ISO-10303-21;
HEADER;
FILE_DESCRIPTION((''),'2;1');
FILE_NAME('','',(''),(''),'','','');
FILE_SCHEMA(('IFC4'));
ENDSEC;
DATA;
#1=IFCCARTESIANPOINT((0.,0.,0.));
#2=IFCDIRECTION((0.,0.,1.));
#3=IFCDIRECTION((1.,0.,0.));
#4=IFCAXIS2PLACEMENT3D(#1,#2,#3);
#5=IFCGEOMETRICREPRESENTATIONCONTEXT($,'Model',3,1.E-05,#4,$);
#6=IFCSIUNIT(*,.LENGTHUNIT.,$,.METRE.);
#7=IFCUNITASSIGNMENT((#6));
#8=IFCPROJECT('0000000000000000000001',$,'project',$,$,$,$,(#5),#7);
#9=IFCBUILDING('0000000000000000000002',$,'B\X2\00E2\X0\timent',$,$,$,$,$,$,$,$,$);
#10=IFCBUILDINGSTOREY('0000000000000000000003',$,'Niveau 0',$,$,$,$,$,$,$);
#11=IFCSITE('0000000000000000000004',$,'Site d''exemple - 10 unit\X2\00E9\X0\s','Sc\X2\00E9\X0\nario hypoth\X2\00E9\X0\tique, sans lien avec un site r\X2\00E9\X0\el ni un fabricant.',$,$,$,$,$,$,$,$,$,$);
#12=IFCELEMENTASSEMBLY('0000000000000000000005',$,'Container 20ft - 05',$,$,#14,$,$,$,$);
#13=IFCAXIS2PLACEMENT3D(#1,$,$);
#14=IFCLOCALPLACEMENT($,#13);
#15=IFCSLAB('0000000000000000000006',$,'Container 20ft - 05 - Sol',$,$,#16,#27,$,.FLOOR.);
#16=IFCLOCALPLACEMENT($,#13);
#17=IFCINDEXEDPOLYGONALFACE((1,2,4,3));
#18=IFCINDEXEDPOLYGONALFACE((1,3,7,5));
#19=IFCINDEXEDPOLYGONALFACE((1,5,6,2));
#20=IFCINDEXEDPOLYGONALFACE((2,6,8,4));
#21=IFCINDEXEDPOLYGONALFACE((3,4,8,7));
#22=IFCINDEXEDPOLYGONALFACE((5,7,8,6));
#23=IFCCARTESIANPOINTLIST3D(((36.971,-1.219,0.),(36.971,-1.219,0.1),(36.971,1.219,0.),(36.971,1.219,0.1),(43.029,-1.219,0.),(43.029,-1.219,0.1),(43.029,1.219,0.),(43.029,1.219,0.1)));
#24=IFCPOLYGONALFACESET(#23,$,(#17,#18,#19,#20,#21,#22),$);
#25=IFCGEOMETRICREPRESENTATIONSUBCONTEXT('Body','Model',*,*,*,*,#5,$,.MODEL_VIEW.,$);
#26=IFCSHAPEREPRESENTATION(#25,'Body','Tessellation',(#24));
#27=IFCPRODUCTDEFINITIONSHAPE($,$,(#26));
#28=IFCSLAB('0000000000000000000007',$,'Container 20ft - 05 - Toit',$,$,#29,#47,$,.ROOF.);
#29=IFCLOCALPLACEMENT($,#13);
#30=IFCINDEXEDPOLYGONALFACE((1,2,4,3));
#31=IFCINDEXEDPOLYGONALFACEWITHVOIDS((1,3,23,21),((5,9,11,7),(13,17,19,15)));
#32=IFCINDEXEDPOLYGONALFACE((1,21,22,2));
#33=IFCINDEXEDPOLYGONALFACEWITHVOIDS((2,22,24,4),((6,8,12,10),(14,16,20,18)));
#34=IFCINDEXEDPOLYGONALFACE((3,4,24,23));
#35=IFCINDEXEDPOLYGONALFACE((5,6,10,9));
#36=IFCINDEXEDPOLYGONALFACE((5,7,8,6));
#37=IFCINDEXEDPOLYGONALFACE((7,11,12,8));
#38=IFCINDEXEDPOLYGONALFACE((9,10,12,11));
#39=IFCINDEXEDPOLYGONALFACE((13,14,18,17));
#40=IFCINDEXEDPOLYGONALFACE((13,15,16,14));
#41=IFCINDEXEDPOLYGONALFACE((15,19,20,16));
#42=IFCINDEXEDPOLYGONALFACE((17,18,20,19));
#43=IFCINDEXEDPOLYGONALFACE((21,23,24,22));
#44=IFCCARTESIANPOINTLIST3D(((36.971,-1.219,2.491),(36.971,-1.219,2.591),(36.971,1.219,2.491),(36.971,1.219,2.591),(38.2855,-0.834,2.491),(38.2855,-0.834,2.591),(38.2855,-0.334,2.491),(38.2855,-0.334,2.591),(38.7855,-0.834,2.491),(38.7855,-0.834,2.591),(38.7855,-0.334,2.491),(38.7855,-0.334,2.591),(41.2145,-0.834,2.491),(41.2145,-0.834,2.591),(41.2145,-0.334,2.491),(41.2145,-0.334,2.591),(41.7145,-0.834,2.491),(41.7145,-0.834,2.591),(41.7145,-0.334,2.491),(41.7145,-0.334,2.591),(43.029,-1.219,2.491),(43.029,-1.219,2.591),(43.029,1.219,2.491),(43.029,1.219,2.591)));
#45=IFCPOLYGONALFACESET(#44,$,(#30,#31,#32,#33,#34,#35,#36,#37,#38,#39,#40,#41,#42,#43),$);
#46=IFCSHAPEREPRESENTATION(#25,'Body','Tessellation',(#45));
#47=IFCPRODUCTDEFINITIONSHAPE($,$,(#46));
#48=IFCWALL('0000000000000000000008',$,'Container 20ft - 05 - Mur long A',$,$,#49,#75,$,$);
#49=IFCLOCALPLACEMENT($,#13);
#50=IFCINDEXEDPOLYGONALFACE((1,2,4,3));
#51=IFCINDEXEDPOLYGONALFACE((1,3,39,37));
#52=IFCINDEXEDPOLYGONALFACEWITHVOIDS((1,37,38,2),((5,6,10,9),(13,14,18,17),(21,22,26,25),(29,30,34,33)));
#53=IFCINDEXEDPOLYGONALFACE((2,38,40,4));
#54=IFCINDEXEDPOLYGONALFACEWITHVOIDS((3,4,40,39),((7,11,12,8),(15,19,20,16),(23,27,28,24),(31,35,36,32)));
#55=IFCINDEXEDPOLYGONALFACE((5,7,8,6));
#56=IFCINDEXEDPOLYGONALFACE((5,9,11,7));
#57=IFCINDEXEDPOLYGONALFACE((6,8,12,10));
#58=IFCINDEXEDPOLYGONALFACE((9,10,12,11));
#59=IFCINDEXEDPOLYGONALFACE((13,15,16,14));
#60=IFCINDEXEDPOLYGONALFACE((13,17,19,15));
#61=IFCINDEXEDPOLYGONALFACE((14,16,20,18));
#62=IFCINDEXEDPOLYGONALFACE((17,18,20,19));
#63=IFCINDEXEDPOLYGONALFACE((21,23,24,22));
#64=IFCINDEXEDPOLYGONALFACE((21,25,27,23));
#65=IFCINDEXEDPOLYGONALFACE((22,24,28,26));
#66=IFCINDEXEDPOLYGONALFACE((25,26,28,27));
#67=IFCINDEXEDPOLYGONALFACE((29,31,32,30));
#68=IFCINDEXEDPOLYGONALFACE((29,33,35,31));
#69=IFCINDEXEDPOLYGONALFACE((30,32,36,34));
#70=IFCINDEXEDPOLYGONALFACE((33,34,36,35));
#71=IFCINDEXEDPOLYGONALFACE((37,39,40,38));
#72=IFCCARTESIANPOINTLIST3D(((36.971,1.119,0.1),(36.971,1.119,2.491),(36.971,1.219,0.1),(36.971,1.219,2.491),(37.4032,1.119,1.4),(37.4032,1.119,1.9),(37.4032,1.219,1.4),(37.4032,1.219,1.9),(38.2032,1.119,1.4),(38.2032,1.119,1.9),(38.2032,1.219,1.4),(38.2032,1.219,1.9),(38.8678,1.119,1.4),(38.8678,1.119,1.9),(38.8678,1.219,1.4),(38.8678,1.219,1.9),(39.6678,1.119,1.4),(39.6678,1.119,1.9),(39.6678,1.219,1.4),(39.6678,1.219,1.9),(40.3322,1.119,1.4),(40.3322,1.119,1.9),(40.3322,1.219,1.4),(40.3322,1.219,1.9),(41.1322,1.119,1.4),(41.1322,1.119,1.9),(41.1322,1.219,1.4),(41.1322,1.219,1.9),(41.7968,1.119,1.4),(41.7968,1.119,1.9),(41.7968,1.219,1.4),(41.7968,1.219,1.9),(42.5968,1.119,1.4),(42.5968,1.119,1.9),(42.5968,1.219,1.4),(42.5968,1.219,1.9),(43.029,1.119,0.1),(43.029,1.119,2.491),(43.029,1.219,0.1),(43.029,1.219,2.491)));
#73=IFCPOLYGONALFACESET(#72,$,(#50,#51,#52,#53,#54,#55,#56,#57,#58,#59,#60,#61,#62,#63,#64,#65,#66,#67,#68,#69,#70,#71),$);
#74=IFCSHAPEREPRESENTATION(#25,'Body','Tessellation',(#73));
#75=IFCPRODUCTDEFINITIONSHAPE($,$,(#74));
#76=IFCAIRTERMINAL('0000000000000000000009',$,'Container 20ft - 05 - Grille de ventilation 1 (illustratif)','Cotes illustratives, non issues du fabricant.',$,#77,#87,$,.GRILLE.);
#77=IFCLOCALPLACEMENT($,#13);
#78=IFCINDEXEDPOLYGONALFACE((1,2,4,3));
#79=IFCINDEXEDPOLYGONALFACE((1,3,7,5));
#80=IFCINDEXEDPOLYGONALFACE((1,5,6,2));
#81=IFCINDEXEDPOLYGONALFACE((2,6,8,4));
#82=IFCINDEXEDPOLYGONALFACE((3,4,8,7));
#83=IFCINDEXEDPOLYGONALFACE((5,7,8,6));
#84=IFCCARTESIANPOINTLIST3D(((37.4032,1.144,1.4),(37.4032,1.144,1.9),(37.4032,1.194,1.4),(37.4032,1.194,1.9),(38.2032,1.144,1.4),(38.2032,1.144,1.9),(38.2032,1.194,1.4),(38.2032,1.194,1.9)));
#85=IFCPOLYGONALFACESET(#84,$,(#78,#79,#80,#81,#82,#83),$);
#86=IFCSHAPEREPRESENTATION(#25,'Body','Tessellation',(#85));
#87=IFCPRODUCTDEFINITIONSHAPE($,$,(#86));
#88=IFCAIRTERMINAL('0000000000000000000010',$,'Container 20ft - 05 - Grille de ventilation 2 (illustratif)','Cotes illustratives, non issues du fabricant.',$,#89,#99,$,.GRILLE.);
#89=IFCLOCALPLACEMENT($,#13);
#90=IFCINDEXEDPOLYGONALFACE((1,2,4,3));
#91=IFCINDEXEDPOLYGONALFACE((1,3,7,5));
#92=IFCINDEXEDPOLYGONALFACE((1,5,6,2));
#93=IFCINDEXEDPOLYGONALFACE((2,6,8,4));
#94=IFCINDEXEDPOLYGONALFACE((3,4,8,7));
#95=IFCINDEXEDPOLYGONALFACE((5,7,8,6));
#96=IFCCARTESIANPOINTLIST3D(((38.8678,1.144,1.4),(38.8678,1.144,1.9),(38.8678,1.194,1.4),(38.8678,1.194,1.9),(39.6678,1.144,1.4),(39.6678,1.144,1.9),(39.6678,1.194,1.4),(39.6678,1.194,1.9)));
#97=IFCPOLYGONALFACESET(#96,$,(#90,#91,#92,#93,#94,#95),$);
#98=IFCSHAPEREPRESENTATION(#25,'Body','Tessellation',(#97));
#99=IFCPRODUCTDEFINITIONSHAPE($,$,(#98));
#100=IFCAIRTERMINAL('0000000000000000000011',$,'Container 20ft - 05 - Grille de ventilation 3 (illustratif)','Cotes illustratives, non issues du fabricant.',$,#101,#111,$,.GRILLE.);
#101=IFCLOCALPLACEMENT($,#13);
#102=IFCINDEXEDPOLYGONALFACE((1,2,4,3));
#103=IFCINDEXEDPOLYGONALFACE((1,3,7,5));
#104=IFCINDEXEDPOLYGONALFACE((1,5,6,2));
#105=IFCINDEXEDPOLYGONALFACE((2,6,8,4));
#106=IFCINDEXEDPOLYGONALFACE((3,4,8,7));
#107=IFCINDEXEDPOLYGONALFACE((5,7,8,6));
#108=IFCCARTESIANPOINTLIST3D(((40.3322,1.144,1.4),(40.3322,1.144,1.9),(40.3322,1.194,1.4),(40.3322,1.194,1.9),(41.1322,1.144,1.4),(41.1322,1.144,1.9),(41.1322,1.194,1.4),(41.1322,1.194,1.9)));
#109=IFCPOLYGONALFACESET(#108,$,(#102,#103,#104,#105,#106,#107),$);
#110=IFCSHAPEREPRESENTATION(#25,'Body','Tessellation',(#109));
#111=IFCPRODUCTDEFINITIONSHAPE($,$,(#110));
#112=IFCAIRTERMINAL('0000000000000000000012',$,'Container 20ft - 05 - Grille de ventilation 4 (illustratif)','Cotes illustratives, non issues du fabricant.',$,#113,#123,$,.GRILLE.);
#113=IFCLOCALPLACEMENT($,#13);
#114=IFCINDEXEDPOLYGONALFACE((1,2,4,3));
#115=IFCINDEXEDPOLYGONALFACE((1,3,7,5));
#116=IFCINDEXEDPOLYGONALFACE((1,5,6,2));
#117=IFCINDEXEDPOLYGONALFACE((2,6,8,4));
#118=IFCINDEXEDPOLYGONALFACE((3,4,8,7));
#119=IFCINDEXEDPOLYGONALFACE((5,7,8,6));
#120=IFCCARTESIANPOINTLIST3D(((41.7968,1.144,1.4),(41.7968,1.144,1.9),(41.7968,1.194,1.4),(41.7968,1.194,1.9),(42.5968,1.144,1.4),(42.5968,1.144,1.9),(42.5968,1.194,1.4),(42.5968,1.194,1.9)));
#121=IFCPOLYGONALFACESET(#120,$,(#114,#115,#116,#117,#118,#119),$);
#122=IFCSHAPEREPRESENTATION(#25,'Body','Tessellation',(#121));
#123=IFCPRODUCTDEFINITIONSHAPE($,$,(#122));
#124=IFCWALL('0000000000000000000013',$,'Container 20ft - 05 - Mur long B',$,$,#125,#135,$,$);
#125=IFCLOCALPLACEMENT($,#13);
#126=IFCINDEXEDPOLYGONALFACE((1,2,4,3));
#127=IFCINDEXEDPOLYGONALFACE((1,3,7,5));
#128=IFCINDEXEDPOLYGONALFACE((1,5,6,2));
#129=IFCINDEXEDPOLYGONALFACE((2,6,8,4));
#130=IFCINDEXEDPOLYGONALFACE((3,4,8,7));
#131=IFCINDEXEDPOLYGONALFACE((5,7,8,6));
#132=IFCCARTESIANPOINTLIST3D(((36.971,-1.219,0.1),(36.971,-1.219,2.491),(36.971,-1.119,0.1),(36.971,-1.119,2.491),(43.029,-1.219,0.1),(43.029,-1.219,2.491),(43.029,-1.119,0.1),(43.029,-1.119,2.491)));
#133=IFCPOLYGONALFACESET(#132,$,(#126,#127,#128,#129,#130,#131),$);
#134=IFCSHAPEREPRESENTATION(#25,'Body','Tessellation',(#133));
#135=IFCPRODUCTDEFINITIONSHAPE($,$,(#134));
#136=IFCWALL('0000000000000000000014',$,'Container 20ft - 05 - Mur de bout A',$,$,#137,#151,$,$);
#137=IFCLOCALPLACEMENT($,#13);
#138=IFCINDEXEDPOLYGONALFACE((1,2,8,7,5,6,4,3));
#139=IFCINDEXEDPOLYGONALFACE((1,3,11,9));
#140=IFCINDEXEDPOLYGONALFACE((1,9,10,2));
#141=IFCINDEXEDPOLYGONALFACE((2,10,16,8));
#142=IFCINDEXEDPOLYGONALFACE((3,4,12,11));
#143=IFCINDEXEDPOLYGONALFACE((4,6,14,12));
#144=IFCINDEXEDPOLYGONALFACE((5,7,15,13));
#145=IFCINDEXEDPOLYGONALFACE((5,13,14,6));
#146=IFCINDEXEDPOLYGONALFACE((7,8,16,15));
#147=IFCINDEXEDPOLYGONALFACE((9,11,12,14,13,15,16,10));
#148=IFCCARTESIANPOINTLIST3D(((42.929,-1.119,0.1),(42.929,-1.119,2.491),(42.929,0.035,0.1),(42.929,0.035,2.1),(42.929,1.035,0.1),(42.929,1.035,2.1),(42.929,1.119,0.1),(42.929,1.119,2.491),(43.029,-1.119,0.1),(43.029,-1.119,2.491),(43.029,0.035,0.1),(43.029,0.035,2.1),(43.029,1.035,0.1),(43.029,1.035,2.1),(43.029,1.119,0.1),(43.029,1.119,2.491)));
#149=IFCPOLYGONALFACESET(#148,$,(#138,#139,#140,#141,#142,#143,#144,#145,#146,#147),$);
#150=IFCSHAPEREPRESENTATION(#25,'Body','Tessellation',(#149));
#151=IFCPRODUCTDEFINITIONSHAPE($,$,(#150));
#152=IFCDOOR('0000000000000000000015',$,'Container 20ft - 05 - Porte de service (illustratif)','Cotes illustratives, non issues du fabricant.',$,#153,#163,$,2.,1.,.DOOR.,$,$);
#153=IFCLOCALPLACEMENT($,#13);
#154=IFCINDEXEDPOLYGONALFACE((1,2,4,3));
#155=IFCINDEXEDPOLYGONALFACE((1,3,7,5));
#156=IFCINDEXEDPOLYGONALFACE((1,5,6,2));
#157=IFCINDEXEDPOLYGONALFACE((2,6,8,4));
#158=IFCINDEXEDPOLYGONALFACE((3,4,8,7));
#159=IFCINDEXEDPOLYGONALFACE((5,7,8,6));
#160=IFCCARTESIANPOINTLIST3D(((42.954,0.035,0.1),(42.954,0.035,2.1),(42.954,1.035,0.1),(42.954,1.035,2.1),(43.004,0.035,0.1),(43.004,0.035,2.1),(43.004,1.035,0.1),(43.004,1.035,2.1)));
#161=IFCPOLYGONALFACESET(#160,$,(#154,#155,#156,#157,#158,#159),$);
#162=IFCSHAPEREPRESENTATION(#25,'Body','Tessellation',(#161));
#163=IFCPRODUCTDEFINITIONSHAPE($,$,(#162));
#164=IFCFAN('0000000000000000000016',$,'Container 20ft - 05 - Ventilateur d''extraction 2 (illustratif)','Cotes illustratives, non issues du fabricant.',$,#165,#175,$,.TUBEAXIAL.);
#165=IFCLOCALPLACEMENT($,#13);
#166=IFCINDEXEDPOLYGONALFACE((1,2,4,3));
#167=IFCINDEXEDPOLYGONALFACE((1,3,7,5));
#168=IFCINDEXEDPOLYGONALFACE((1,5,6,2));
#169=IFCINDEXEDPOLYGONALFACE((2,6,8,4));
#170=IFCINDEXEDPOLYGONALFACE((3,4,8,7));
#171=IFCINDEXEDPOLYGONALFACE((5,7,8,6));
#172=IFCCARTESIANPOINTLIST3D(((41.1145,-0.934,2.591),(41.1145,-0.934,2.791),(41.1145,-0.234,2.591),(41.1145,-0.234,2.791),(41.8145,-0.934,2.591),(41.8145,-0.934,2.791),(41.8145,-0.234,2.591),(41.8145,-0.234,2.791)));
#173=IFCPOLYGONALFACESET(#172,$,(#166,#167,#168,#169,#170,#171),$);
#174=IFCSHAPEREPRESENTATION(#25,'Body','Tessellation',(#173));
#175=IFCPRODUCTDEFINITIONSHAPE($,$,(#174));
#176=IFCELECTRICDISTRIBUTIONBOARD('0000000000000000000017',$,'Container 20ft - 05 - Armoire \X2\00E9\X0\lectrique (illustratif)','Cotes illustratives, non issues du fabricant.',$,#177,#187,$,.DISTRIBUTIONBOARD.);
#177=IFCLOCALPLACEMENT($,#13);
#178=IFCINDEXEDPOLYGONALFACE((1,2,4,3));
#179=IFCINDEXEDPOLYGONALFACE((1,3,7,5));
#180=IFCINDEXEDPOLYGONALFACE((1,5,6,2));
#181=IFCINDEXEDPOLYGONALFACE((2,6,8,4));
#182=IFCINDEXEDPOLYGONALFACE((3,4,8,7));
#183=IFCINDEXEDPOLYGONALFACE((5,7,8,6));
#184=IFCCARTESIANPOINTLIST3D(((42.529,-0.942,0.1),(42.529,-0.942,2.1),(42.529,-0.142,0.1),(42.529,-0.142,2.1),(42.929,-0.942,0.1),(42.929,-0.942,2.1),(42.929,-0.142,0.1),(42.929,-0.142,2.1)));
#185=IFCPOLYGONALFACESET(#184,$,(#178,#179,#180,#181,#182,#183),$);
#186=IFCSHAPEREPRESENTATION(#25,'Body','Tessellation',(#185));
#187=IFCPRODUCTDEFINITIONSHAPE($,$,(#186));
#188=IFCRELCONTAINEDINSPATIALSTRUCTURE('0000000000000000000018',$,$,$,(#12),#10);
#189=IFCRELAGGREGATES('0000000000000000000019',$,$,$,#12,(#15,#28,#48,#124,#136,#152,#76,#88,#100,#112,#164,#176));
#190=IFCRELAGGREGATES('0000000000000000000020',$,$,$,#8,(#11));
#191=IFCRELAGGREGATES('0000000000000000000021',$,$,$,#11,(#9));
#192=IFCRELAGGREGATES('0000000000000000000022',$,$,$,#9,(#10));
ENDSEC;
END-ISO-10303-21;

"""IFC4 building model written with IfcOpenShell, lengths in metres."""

from ifc_helpers import new_model, si_unit, frame, origin_with_axes, place, context, subcontext, project, spatial, rectangle, extrude, element, fill, aggregate, save


model = new_model("IFC4")

# Units and contexts
model_context = context("Model", 3, precision=1e-05, world=origin_with_axes())
body_context = subcontext(model_context, "Body", "Model", "MODEL_VIEW")
ifc_project = project(units=[si_unit("LENGTHUNIT", "METRE")], contexts=[model_context])

# Site, building, storey
site = spatial("IfcSite", under=ifc_project, Name="Site d'exemple - 10 unités", Description="Scénario hypothétique, sans lien avec un site réel ni un fabricant.")
building = spatial("IfcBuilding", under=site, Name="Bâtiment")
storey = spatial("IfcBuildingStorey", under=building, Name="Niveau 0")

# Element assembly, slabs, openings, walls, air terminals, door, fan, electric distribution board
assembly = element("IfcElementAssembly", 1, inside=storey, Name="Container 20ft - 05")
slab_1_placement = place(None, frame((40.0, 0.0, 0.0), z_axis=(0.0, 0.0, 1.0), x_axis=(1.0, 0.0, 0.0)))
slab_1 = element("IfcSlab", 2, at=slab_1_placement, Name="Container 20ft - 05 - Sol", PredefinedType="FLOOR", context=body_context, shape_type="SweptSolid", body=[
    extrude(rectangle(XDim=6.058, YDim=2.438), origin_with_axes(), (0.0, 0.0, 1.0), 0.1),
])
slab_2_placement = place(None, frame((40.0, 0.0, 2.491), z_axis=(0.0, 0.0, 1.0), x_axis=(1.0, 0.0, 0.0)))
slab_2 = element("IfcSlab", 3, at=slab_2_placement, Name="Container 20ft - 05 - Toit", PredefinedType="ROOF", context=body_context, shape_type="SweptSolid", body=[
    extrude(rectangle(XDim=6.058, YDim=2.438), origin_with_axes(), (0.0, 0.0, 1.0), 0.1),
])
opening_1_placement = place(None, frame((38.5355, -0.584, 2.441), z_axis=(0.0, 0.0, 1.0), x_axis=(1.0, 0.0, 0.0)))
element("IfcOpeningElement", 4, at=opening_1_placement, cuts=slab_2, PredefinedType="OPENING", context=body_context, shape_type="SweptSolid", body=[
    extrude(rectangle(XDim=0.5, YDim=0.5), origin_with_axes(), (0.0, 0.0, 1.0), 0.2),
])
opening_2_placement = place(None, frame((41.4645, -0.584, 2.441), z_axis=(0.0, 0.0, 1.0), x_axis=(1.0, 0.0, 0.0)))
element("IfcOpeningElement", 5, at=opening_2_placement, cuts=slab_2, PredefinedType="OPENING", context=body_context, shape_type="SweptSolid", body=[
    extrude(rectangle(XDim=0.5, YDim=0.5), origin_with_axes(), (0.0, 0.0, 1.0), 0.2),
])
wall_1_placement = place(None, frame((40.0, 1.169, 0.1), z_axis=(0.0, 0.0, 1.0), x_axis=(1.0, 0.0, 0.0)))
wall_1 = element("IfcWall", 6, at=wall_1_placement, Name="Container 20ft - 05 - Mur long A", context=body_context, shape_type="SweptSolid", body=[
    extrude(rectangle(XDim=6.058, YDim=0.1), origin_with_axes(), (0.0, 0.0, 1.0), 2.391),
])
opening_3_placement = place(None, frame((37.8032, 1.169, 1.4), z_axis=(0.0, 0.0, 1.0), x_axis=(1.0, 0.0, 0.0)))
opening_3 = element("IfcOpeningElement", 7, at=opening_3_placement, cuts=wall_1, PredefinedType="OPENING", context=body_context, shape_type="SweptSolid", body=[
    extrude(rectangle(XDim=0.8, YDim=0.2), origin_with_axes(), (0.0, 0.0, 1.0), 0.5),
])
opening_4_placement = place(None, frame((39.2677, 1.169, 1.4), z_axis=(0.0, 0.0, 1.0), x_axis=(1.0, 0.0, 0.0)))
opening_4 = element("IfcOpeningElement", 8, at=opening_4_placement, cuts=wall_1, PredefinedType="OPENING", context=body_context, shape_type="SweptSolid", body=[
    extrude(rectangle(XDim=0.8, YDim=0.2), origin_with_axes(), (0.0, 0.0, 1.0), 0.5),
])
opening_5_placement = place(None, frame((40.7323, 1.169, 1.4), z_axis=(0.0, 0.0, 1.0), x_axis=(1.0, 0.0, 0.0)))
opening_5 = element("IfcOpeningElement", 9, at=opening_5_placement, cuts=wall_1, PredefinedType="OPENING", context=body_context, shape_type="SweptSolid", body=[
    extrude(rectangle(XDim=0.8, YDim=0.2), origin_with_axes(), (0.0, 0.0, 1.0), 0.5),
])
opening_6_placement = place(None, frame((42.1968, 1.169, 1.4), z_axis=(0.0, 0.0, 1.0), x_axis=(1.0, 0.0, 0.0)))
opening_6 = element("IfcOpeningElement", 10, at=opening_6_placement, cuts=wall_1, PredefinedType="OPENING", context=body_context, shape_type="SweptSolid", body=[
    extrude(rectangle(XDim=0.8, YDim=0.2), origin_with_axes(), (0.0, 0.0, 1.0), 0.5),
])
air_terminal_1_placement = place(None, frame((37.8032, 1.169, 1.4), z_axis=(0.0, 0.0, 1.0), x_axis=(1.0, 0.0, 0.0)))
air_terminal_1 = element("IfcAirTerminal", 11, at=air_terminal_1_placement, Name="Container 20ft - 05 - Grille de ventilation 1 (illustratif)", Description="Cotes illustratives, non issues du fabricant.", PredefinedType="GRILLE", context=body_context, shape_type="SweptSolid", body=[
    extrude(rectangle(XDim=0.8, YDim=0.05), origin_with_axes(), (0.0, 0.0, 1.0), 0.5),
])
fill(opening_3, air_terminal_1)
air_terminal_2_placement = place(None, frame((39.2677, 1.169, 1.4), z_axis=(0.0, 0.0, 1.0), x_axis=(1.0, 0.0, 0.0)))
air_terminal_2 = element("IfcAirTerminal", 12, at=air_terminal_2_placement, Name="Container 20ft - 05 - Grille de ventilation 2 (illustratif)", Description="Cotes illustratives, non issues du fabricant.", PredefinedType="GRILLE", context=body_context, shape_type="SweptSolid", body=[
    extrude(rectangle(XDim=0.8, YDim=0.05), origin_with_axes(), (0.0, 0.0, 1.0), 0.5),
])
fill(opening_4, air_terminal_2)
air_terminal_3_placement = place(None, frame((40.7323, 1.169, 1.4), z_axis=(0.0, 0.0, 1.0), x_axis=(1.0, 0.0, 0.0)))
air_terminal_3 = element("IfcAirTerminal", 13, at=air_terminal_3_placement, Name="Container 20ft - 05 - Grille de ventilation 3 (illustratif)", Description="Cotes illustratives, non issues du fabricant.", PredefinedType="GRILLE", context=body_context, shape_type="SweptSolid", body=[
    extrude(rectangle(XDim=0.8, YDim=0.05), origin_with_axes(), (0.0, 0.0, 1.0), 0.5),
])
fill(opening_5, air_terminal_3)
air_terminal_4_placement = place(None, frame((42.1968, 1.169, 1.4), z_axis=(0.0, 0.0, 1.0), x_axis=(1.0, 0.0, 0.0)))
air_terminal_4 = element("IfcAirTerminal", 14, at=air_terminal_4_placement, Name="Container 20ft - 05 - Grille de ventilation 4 (illustratif)", Description="Cotes illustratives, non issues du fabricant.", PredefinedType="GRILLE", context=body_context, shape_type="SweptSolid", body=[
    extrude(rectangle(XDim=0.8, YDim=0.05), origin_with_axes(), (0.0, 0.0, 1.0), 0.5),
])
fill(opening_6, air_terminal_4)
wall_2_placement = place(None, frame((40.0, -1.169, 0.1), z_axis=(0.0, 0.0, 1.0), x_axis=(1.0, 0.0, 0.0)))
wall_2 = element("IfcWall", 15, at=wall_2_placement, Name="Container 20ft - 05 - Mur long B", context=body_context, shape_type="SweptSolid", body=[
    extrude(rectangle(XDim=6.058, YDim=0.1), origin_with_axes(), (0.0, 0.0, 1.0), 2.391),
])
wall_3_placement = place(None, frame((42.979, 0.0, 0.1), z_axis=(0.0, 0.0, 1.0), x_axis=(1.0, 0.0, 0.0)))
wall_3 = element("IfcWall", 16, at=wall_3_placement, Name="Container 20ft - 05 - Mur de bout A", context=body_context, shape_type="SweptSolid", body=[
    extrude(rectangle(XDim=0.1, YDim=2.238), origin_with_axes(), (0.0, 0.0, 1.0), 2.391),
])
opening_7_placement = place(None, frame((42.979, 0.535, 0.1), z_axis=(0.0, 0.0, 1.0), x_axis=(1.0, 0.0, 0.0)))
opening_7 = element("IfcOpeningElement", 17, at=opening_7_placement, cuts=wall_3, PredefinedType="OPENING", context=body_context, shape_type="SweptSolid", body=[
    extrude(rectangle(XDim=0.2, YDim=1.0), origin_with_axes(), (0.0, 0.0, 1.0), 2.0),
])
door_placement = place(None, frame((42.979, 0.535, 0.1), z_axis=(0.0, 0.0, 1.0), x_axis=(1.0, 0.0, 0.0)))
door = element("IfcDoor", 18, at=door_placement, Name="Container 20ft - 05 - Porte de service (illustratif)", Description="Cotes illustratives, non issues du fabricant.", OverallHeight=2.0, OverallWidth=1.0, PredefinedType="DOOR", context=body_context, shape_type="SweptSolid", body=[
    extrude(rectangle(XDim=0.05, YDim=1.0), origin_with_axes(), (0.0, 0.0, 1.0), 2.0),
])
fill(opening_7, door)
fan_placement = place(None, frame((41.4645, -0.584, 2.591), z_axis=(0.0, 0.0, 1.0), x_axis=(1.0, 0.0, 0.0)))
fan = element("IfcFan", 19, at=fan_placement, Name="Container 20ft - 05 - Ventilateur d'extraction 2 (illustratif)", Description="Cotes illustratives, non issues du fabricant.", PredefinedType="TUBEAXIAL", context=body_context, shape_type="SweptSolid", body=[
    extrude(rectangle(XDim=0.7, YDim=0.7), origin_with_axes(), (0.0, 0.0, 1.0), 0.2),
])
electric_distribution_board_placement = place(None, frame((42.729, -0.542, 0.1), z_axis=(0.0, 0.0, 1.0), x_axis=(1.0, 0.0, 0.0)))
electric_distribution_board = element("IfcElectricDistributionBoard", 20, at=electric_distribution_board_placement, Name="Container 20ft - 05 - Armoire électrique (illustratif)", Description="Cotes illustratives, non issues du fabricant.", PredefinedType="DISTRIBUTIONBOARD", context=body_context, shape_type="SweptSolid", body=[
    extrude(rectangle(XDim=0.4, YDim=0.8), origin_with_axes(), (0.0, 0.0, 1.0), 2.0),
])
aggregate(assembly, [slab_1, slab_2, wall_1, wall_2, wall_3, door, air_terminal_1, air_terminal_2, air_terminal_3, air_terminal_4, fan, electric_distribution_board])

save(model, "model.ifc")
